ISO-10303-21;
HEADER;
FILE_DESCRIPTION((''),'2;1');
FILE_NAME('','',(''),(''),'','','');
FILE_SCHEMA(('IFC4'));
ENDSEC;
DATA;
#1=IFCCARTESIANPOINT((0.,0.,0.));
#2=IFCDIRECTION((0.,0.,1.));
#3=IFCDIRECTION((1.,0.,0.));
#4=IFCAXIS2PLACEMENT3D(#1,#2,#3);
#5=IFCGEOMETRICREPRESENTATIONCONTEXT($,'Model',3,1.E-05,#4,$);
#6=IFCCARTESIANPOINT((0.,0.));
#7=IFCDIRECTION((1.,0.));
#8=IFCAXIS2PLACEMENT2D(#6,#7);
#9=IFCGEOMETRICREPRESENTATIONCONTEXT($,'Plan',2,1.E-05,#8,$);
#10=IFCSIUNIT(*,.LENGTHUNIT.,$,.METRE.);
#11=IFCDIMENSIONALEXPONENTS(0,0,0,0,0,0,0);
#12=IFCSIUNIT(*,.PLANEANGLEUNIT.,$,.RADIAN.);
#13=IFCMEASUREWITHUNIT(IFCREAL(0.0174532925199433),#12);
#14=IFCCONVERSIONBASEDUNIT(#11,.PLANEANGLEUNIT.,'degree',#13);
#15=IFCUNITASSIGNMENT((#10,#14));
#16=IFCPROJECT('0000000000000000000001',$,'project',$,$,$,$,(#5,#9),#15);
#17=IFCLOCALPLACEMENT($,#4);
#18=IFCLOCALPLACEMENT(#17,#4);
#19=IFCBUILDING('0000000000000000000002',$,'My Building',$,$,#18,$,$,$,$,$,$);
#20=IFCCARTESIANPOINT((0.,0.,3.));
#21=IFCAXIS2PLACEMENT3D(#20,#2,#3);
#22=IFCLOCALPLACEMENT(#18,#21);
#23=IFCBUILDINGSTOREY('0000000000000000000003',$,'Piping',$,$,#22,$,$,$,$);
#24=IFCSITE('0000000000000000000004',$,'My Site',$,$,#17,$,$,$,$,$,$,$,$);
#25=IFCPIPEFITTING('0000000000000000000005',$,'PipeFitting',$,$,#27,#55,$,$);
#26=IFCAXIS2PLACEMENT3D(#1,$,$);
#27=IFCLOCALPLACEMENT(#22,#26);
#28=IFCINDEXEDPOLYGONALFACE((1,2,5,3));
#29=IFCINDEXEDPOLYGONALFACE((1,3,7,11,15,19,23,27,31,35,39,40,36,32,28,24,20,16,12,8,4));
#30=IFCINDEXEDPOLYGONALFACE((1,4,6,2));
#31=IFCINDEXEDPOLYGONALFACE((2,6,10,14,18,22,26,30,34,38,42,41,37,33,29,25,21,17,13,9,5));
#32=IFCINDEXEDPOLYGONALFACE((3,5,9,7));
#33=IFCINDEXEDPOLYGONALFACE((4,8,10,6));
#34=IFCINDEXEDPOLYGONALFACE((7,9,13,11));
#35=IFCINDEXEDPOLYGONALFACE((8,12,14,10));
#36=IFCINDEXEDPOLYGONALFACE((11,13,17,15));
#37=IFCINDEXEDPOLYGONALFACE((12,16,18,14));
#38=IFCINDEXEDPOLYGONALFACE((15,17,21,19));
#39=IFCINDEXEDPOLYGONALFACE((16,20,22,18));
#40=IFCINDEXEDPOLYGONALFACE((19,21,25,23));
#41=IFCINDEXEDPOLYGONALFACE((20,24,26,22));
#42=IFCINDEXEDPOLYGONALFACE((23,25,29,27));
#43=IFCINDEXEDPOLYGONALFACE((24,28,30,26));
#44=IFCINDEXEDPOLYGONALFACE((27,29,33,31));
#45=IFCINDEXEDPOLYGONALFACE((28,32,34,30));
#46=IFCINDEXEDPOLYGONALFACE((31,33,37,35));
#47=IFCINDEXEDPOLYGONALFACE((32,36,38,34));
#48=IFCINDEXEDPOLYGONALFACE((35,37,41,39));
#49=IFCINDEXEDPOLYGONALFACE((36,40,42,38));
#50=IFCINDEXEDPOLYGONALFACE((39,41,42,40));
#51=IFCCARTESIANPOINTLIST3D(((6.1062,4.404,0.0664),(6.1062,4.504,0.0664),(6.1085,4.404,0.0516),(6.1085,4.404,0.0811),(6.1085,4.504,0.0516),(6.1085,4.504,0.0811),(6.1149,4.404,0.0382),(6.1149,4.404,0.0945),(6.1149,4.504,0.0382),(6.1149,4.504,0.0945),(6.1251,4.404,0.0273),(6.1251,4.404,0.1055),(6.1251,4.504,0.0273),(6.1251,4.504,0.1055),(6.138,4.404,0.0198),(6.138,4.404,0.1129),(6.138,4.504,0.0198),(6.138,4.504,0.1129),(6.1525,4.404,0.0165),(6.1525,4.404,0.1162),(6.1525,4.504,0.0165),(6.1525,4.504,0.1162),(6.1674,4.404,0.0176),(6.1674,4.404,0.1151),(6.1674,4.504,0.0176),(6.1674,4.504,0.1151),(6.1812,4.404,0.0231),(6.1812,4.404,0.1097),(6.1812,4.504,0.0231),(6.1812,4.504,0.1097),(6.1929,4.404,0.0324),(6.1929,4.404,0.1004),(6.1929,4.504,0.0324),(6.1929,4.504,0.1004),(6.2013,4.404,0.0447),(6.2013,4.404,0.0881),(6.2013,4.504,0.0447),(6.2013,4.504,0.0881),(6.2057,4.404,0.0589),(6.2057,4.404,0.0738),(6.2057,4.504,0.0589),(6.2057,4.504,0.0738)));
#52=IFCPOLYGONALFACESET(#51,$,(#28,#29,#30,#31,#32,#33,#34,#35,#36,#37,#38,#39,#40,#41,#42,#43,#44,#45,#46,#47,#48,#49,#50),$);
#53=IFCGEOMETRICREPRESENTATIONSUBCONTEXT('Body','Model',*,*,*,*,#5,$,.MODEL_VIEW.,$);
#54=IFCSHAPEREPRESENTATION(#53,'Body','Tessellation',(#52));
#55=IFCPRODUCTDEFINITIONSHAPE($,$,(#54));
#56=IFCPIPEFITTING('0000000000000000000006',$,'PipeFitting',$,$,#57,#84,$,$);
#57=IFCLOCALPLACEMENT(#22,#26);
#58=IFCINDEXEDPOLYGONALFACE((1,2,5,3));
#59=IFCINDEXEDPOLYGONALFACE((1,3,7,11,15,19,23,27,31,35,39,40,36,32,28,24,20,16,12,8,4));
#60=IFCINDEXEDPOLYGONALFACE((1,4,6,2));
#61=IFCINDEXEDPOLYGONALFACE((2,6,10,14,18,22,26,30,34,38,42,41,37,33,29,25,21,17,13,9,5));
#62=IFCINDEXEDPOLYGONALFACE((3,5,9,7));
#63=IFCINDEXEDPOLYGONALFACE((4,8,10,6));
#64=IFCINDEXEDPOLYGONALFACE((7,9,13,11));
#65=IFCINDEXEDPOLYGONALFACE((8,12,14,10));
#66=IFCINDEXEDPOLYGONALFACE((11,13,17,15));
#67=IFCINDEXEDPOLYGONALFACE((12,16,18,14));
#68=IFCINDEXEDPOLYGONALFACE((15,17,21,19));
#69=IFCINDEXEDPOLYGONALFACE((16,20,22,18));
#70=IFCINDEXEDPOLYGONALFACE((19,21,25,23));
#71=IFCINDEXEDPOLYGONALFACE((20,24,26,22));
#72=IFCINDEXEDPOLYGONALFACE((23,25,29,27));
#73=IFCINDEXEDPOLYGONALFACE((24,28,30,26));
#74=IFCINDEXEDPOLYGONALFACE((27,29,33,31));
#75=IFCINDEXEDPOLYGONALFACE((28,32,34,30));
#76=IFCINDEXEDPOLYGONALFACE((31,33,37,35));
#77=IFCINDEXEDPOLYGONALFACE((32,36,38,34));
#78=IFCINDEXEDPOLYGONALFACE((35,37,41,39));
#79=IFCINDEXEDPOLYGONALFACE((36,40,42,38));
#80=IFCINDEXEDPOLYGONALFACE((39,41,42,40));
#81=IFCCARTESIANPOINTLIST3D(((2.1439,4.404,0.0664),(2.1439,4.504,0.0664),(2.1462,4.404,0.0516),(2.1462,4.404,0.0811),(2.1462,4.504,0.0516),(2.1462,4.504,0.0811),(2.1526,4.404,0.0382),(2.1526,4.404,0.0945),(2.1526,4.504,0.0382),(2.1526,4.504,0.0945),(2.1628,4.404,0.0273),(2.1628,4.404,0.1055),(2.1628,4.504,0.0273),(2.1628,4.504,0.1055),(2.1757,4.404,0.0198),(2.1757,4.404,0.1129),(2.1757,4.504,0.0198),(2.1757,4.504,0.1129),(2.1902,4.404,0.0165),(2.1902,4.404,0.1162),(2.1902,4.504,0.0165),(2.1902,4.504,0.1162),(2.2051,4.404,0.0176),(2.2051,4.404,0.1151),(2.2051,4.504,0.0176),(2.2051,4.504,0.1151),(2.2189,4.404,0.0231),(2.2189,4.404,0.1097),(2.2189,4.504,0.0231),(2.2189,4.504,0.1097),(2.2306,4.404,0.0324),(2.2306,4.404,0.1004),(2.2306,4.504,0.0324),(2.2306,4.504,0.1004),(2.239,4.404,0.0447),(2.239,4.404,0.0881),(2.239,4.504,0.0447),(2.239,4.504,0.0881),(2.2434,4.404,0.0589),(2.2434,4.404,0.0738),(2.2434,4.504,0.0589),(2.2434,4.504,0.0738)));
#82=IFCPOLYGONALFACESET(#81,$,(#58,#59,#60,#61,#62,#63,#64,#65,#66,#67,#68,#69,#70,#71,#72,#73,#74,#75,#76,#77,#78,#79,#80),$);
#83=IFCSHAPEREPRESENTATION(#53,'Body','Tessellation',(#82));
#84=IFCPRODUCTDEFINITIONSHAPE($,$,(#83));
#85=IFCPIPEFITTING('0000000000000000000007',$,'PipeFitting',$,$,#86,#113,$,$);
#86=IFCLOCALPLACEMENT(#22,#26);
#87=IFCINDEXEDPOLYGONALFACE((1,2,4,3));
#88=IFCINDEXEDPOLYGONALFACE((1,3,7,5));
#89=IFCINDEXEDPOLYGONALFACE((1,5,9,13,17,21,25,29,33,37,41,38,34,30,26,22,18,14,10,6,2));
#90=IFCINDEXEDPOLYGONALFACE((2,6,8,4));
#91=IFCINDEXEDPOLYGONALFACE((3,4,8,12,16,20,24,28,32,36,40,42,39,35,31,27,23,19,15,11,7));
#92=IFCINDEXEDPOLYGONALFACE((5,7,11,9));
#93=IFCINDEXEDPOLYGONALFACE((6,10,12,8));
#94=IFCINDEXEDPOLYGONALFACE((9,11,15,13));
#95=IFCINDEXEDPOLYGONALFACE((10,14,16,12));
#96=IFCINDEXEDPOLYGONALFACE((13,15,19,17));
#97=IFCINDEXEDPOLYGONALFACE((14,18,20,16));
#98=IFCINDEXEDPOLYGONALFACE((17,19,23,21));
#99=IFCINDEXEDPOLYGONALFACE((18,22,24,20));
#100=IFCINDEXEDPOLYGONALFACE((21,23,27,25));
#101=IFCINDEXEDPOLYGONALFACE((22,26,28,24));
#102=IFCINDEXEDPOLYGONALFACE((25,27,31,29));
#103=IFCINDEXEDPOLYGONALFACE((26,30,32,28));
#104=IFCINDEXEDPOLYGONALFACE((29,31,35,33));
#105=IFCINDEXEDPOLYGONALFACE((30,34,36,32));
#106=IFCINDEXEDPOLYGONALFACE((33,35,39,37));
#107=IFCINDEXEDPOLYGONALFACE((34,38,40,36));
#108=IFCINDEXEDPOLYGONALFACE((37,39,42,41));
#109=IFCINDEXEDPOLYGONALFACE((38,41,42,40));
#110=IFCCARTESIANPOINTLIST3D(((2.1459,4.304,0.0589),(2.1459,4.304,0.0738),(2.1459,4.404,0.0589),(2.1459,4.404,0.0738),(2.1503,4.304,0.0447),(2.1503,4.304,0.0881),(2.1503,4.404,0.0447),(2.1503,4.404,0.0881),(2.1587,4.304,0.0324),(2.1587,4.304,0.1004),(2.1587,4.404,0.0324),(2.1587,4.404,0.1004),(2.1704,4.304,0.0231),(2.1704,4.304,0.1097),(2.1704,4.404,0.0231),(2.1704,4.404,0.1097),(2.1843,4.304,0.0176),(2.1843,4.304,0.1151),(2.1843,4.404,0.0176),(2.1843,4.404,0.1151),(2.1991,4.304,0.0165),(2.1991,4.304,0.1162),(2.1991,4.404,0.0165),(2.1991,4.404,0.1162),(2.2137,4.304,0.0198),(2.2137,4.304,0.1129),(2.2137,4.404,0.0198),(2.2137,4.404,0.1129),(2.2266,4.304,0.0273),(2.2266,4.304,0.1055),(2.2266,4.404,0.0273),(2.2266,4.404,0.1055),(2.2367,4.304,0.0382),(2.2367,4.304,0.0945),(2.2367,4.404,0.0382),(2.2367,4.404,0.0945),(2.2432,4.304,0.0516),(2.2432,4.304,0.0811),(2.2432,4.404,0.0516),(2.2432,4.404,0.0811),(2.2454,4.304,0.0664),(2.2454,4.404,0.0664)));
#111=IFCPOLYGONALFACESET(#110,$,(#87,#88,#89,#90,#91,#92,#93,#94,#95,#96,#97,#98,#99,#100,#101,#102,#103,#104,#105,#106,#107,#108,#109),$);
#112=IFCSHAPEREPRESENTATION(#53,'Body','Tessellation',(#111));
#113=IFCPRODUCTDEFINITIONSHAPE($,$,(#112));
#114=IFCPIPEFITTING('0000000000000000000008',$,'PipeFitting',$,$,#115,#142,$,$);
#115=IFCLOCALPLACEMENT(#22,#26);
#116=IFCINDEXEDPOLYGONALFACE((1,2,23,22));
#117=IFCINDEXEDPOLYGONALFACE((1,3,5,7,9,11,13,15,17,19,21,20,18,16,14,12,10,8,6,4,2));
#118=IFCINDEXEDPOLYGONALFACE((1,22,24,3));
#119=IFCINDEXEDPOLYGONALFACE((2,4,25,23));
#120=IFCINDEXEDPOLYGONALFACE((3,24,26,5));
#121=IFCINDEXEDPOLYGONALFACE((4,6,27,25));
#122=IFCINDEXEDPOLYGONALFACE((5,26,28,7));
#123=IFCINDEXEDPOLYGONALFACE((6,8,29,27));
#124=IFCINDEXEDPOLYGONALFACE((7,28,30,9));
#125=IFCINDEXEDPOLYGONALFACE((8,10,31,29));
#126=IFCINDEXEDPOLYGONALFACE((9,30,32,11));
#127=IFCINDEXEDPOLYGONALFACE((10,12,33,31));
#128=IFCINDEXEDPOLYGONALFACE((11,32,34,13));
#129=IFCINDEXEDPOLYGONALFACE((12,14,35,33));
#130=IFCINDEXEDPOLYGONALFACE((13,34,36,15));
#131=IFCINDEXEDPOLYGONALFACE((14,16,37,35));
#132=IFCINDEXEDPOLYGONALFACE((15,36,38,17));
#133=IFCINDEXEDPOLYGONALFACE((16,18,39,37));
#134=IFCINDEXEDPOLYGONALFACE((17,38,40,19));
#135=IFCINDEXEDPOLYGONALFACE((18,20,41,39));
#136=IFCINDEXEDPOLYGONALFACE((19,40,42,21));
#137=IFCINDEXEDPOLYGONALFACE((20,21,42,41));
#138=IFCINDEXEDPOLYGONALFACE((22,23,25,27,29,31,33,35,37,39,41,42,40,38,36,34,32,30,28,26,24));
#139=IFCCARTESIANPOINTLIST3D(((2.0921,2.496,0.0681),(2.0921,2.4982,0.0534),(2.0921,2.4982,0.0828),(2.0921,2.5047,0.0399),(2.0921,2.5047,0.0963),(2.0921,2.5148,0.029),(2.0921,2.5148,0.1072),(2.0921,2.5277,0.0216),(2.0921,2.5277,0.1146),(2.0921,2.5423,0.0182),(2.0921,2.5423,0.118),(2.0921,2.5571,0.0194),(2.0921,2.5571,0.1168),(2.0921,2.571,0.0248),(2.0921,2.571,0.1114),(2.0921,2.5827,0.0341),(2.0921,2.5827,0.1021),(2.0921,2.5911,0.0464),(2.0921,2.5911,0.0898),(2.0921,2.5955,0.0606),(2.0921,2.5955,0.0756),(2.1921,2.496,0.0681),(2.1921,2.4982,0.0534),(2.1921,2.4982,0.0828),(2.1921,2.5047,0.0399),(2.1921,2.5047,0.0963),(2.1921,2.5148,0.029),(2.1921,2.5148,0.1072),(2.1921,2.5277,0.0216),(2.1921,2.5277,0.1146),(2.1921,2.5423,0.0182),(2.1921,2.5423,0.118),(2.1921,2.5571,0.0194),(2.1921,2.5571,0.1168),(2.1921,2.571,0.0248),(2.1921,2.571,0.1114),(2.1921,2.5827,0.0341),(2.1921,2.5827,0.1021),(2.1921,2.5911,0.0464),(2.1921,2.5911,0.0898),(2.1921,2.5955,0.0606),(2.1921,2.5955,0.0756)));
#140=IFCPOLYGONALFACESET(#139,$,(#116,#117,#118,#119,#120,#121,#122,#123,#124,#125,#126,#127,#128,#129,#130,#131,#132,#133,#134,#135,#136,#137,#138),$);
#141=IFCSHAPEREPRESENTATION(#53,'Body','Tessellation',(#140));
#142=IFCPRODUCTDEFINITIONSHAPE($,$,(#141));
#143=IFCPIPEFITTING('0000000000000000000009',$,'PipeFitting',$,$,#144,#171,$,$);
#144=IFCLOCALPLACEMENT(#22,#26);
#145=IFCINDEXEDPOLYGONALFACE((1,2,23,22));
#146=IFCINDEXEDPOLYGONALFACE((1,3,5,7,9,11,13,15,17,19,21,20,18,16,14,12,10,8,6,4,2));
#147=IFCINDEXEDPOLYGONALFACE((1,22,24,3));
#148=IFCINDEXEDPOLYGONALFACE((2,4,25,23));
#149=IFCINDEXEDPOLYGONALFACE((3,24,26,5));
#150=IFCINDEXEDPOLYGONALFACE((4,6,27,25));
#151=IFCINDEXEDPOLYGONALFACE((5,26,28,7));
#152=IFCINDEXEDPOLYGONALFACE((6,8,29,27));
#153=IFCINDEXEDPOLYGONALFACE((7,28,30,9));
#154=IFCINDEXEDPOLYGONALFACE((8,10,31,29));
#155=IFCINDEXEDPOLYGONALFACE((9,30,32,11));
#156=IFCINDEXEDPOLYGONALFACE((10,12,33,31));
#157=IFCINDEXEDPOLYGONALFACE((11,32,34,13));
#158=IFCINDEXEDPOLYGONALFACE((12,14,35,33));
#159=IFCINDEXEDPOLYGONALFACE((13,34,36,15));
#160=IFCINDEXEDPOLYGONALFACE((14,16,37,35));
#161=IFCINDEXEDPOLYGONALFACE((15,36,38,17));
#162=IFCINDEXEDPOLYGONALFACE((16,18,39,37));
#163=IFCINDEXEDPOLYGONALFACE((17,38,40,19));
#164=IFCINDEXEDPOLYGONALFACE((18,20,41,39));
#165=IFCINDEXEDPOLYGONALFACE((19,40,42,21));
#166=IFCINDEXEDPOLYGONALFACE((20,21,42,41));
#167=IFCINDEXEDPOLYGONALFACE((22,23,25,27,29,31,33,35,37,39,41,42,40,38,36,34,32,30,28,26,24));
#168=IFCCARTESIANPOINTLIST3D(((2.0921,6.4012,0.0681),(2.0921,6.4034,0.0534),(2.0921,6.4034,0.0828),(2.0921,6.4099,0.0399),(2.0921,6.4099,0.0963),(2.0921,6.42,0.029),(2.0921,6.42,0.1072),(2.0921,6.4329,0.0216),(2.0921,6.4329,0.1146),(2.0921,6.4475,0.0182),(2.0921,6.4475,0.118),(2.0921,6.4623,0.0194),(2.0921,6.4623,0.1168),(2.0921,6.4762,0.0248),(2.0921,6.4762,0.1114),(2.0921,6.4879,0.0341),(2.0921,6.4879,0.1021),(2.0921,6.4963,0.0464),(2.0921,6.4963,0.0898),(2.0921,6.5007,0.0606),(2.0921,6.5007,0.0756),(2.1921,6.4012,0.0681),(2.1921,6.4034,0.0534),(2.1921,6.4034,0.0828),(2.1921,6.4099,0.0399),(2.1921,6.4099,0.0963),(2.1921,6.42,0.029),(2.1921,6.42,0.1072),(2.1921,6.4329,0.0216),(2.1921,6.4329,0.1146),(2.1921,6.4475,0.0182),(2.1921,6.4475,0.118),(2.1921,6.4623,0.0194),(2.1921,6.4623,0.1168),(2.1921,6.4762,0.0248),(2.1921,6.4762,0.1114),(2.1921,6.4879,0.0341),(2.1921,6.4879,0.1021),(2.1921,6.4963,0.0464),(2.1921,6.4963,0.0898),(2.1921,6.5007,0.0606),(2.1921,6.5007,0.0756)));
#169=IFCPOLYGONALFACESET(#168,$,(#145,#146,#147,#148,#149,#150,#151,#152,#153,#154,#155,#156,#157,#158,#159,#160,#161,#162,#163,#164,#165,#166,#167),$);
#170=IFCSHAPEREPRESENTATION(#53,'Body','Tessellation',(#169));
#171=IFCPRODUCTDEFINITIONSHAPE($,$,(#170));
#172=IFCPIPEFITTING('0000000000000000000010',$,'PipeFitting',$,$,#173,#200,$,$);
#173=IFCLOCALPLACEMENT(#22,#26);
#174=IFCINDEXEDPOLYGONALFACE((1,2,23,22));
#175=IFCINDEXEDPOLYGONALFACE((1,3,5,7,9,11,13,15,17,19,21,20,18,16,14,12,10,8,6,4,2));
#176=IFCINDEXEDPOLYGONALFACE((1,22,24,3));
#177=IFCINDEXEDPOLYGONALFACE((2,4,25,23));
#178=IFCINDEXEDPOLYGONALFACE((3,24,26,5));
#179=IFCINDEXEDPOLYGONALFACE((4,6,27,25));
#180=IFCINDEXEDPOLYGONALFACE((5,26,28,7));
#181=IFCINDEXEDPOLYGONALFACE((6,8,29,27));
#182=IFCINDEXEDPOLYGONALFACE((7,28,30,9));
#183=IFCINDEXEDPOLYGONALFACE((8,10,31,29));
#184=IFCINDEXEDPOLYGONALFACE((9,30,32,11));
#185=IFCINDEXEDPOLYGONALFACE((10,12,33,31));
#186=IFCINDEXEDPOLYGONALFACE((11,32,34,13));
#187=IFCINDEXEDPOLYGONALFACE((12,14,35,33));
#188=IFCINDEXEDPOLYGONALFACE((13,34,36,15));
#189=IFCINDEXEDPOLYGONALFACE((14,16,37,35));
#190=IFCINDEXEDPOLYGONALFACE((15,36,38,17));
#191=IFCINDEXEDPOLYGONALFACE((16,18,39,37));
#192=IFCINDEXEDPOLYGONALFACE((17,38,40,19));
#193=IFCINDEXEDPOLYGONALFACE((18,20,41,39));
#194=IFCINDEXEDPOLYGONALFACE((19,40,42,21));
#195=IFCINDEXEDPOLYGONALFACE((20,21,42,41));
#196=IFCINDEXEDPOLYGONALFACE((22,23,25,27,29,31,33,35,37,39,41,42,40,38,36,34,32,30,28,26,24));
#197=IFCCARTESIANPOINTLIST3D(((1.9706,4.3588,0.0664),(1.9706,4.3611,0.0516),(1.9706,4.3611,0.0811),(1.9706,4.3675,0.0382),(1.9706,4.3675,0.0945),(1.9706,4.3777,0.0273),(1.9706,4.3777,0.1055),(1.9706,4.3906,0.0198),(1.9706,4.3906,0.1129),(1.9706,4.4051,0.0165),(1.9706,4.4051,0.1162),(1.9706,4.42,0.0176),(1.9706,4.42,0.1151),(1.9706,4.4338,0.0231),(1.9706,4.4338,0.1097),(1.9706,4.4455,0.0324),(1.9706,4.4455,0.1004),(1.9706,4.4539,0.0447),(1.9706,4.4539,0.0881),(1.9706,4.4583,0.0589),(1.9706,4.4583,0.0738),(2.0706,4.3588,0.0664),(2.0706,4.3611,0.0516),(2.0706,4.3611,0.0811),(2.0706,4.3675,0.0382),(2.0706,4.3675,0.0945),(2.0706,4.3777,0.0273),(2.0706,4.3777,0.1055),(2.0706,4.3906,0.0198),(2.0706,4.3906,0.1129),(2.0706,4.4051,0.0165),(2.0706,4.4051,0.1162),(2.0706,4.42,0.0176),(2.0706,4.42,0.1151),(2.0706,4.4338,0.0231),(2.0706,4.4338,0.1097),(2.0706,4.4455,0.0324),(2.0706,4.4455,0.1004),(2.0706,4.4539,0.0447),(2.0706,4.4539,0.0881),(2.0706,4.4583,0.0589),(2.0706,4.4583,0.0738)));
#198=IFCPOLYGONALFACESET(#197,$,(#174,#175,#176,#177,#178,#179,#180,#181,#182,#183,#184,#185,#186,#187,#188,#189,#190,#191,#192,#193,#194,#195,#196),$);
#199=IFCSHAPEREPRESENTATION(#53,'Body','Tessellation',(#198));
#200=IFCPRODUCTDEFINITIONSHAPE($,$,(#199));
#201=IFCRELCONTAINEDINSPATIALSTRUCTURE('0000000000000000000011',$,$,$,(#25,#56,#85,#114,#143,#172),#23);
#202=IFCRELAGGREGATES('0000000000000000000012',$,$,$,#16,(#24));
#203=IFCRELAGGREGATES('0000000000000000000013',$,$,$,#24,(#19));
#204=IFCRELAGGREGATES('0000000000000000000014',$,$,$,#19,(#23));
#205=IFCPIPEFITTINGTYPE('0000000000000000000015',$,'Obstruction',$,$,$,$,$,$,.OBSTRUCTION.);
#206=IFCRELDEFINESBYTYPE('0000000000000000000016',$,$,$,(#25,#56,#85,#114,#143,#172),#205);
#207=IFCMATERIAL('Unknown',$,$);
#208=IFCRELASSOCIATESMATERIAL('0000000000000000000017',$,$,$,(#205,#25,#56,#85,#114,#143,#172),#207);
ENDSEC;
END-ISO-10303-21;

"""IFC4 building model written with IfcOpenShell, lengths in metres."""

from ifc_helpers import new_model, entity, si_unit, converted_unit, frame, origin_with_axes, origin_2d_with_axis, place, context, subcontext, project, spatial, circle, extrude, material, material_profile, profile_set, profile_usage, type_object, element, save


model = new_model("IFC4")

# Units and contexts
model_context = context("Model", 3, precision=1e-05, world=origin_with_axes())
plan_context = context("Plan", 2, precision=1e-05, world=origin_2d_with_axis())
body_context = subcontext(model_context, "Body", "Model", "MODEL_VIEW")
ifc_project = project(units=[si_unit("LENGTHUNIT", "METRE"), converted_unit("PLANEANGLEUNIT", "degree", entity("IfcReal", 0.0174532925199433), si_unit("PLANEANGLEUNIT", "RADIAN"), dimensions=[0, 0, 0, 0, 0, 0, 0])], contexts=[model_context, plan_context])

# Site, building, storey
site_placement = place(None, origin_with_axes())
site = spatial("IfcSite", under=ifc_project, at=site_placement, Name="My Site")
building_placement = place(site_placement, origin_with_axes())
building = spatial("IfcBuilding", under=site, at=building_placement, Name="My Building")
storey_placement = place(building_placement, frame((0.0, 0.0, 3.0), z_axis=(0.0, 0.0, 1.0), x_axis=(1.0, 0.0, 0.0)))
storey = spatial("IfcBuildingStorey", under=building, at=storey_placement, Name="Piping")

# Shared definitions
ifc_material = material(Name="Unknown")

# Pipe fittings
ifc_material_profile_1 = material_profile(ifc_material, circle(Radius=0.05))
ifc_profile_set_1 = profile_set([ifc_material_profile_1])
ifc_profile_usage_1 = profile_usage(ifc_profile_set_1, cardinal=5)
pipe_fitting_type_1 = type_object("IfcPipeFittingType", Name="Obstruction", PredefinedType="OBSTRUCTION", material=ifc_profile_set_1)
pipe_fitting_1_placement = place(storey_placement, frame((6.1562, 4.404, 0.0664), z_axis=(0.0, 1.0, 0.0), x_axis=(-1.0, 0.0, 0.0)))
element("IfcPipeFitting", 1, at=pipe_fitting_1_placement, inside=storey, type_object=pipe_fitting_type_1, material=ifc_profile_usage_1, Name="PipeFitting", context=body_context, shape_type="SweptSolid", body=[
    extrude(circle(Radius=0.05), origin_with_axes(), (0.0, 0.0, 1.0), 0.1),
])
ifc_profile_usage_2 = profile_usage(ifc_profile_set_1, cardinal=5)
pipe_fitting_2_placement = place(storey_placement, frame((2.1939, 4.404, 0.0664), z_axis=(0.0, 1.0, 0.0), x_axis=(-1.0, 0.0, 0.0)))
element("IfcPipeFitting", 2, at=pipe_fitting_2_placement, inside=storey, type_object=pipe_fitting_type_1, material=ifc_profile_usage_2, Name="PipeFitting", context=body_context, shape_type="SweptSolid", body=[
    extrude(circle(Radius=0.05), origin_with_axes(), (0.0, 0.0, 1.0), 0.1),
])
ifc_profile_usage_3 = profile_usage(ifc_profile_set_1, cardinal=5)
pipe_fitting_3_placement = place(storey_placement, frame((2.1954, 4.404, 0.0664), z_axis=(0.0, -1.0, 0.000002), x_axis=(1.0, 0.0, 0.0)))
element("IfcPipeFitting", 3, at=pipe_fitting_3_placement, inside=storey, type_object=pipe_fitting_type_1, material=ifc_profile_usage_3, Name="PipeFitting", context=body_context, shape_type="SweptSolid", body=[
    extrude(circle(Radius=0.05), origin_with_axes(), (0.0, 0.0, 1.0), 0.1),
])
ifc_profile_usage_4 = profile_usage(ifc_profile_set_1, cardinal=5)
pipe_fitting_4_placement = place(storey_placement, frame((2.1921, 2.546, 0.0681), z_axis=(-1.0, 0.0, 0.0), x_axis=(0.0, -1.0, 0.0)))
element("IfcPipeFitting", 4, at=pipe_fitting_4_placement, inside=storey, type_object=pipe_fitting_type_1, material=ifc_profile_usage_4, Name="PipeFitting", context=body_context, shape_type="SweptSolid", body=[
    extrude(circle(Radius=0.05), origin_with_axes(), (0.0, 0.0, 1.0), 0.1),
])
ifc_profile_usage_5 = profile_usage(ifc_profile_set_1, cardinal=5)
pipe_fitting_5_placement = place(storey_placement, frame((2.1921, 6.4512, 0.0681), z_axis=(-1.0, 0.0, 0.0), x_axis=(0.0, -1.0, 0.0)))
element("IfcPipeFitting", 5, at=pipe_fitting_5_placement, inside=storey, type_object=pipe_fitting_type_1, material=ifc_profile_usage_5, Name="PipeFitting", context=body_context, shape_type="SweptSolid", body=[
    extrude(circle(Radius=0.05), origin_with_axes(), (0.0, 0.0, 1.0), 0.1),
])
ifc_profile_usage_6 = profile_usage(ifc_profile_set_1, cardinal=5)
pipe_fitting_6_placement = place(storey_placement, frame((2.0706, 4.4088, 0.0664), z_axis=(-1.0, 0.0, 0.0), x_axis=(0.0, -1.0, 0.0)))
element("IfcPipeFitting", 6, at=pipe_fitting_6_placement, inside=storey, type_object=pipe_fitting_type_1, material=ifc_profile_usage_6, Name="PipeFitting", context=body_context, shape_type="SweptSolid", body=[
    extrude(circle(Radius=0.05), origin_with_axes(), (0.0, 0.0, 1.0), 0.1),
])

save(model, "model.ifc")
